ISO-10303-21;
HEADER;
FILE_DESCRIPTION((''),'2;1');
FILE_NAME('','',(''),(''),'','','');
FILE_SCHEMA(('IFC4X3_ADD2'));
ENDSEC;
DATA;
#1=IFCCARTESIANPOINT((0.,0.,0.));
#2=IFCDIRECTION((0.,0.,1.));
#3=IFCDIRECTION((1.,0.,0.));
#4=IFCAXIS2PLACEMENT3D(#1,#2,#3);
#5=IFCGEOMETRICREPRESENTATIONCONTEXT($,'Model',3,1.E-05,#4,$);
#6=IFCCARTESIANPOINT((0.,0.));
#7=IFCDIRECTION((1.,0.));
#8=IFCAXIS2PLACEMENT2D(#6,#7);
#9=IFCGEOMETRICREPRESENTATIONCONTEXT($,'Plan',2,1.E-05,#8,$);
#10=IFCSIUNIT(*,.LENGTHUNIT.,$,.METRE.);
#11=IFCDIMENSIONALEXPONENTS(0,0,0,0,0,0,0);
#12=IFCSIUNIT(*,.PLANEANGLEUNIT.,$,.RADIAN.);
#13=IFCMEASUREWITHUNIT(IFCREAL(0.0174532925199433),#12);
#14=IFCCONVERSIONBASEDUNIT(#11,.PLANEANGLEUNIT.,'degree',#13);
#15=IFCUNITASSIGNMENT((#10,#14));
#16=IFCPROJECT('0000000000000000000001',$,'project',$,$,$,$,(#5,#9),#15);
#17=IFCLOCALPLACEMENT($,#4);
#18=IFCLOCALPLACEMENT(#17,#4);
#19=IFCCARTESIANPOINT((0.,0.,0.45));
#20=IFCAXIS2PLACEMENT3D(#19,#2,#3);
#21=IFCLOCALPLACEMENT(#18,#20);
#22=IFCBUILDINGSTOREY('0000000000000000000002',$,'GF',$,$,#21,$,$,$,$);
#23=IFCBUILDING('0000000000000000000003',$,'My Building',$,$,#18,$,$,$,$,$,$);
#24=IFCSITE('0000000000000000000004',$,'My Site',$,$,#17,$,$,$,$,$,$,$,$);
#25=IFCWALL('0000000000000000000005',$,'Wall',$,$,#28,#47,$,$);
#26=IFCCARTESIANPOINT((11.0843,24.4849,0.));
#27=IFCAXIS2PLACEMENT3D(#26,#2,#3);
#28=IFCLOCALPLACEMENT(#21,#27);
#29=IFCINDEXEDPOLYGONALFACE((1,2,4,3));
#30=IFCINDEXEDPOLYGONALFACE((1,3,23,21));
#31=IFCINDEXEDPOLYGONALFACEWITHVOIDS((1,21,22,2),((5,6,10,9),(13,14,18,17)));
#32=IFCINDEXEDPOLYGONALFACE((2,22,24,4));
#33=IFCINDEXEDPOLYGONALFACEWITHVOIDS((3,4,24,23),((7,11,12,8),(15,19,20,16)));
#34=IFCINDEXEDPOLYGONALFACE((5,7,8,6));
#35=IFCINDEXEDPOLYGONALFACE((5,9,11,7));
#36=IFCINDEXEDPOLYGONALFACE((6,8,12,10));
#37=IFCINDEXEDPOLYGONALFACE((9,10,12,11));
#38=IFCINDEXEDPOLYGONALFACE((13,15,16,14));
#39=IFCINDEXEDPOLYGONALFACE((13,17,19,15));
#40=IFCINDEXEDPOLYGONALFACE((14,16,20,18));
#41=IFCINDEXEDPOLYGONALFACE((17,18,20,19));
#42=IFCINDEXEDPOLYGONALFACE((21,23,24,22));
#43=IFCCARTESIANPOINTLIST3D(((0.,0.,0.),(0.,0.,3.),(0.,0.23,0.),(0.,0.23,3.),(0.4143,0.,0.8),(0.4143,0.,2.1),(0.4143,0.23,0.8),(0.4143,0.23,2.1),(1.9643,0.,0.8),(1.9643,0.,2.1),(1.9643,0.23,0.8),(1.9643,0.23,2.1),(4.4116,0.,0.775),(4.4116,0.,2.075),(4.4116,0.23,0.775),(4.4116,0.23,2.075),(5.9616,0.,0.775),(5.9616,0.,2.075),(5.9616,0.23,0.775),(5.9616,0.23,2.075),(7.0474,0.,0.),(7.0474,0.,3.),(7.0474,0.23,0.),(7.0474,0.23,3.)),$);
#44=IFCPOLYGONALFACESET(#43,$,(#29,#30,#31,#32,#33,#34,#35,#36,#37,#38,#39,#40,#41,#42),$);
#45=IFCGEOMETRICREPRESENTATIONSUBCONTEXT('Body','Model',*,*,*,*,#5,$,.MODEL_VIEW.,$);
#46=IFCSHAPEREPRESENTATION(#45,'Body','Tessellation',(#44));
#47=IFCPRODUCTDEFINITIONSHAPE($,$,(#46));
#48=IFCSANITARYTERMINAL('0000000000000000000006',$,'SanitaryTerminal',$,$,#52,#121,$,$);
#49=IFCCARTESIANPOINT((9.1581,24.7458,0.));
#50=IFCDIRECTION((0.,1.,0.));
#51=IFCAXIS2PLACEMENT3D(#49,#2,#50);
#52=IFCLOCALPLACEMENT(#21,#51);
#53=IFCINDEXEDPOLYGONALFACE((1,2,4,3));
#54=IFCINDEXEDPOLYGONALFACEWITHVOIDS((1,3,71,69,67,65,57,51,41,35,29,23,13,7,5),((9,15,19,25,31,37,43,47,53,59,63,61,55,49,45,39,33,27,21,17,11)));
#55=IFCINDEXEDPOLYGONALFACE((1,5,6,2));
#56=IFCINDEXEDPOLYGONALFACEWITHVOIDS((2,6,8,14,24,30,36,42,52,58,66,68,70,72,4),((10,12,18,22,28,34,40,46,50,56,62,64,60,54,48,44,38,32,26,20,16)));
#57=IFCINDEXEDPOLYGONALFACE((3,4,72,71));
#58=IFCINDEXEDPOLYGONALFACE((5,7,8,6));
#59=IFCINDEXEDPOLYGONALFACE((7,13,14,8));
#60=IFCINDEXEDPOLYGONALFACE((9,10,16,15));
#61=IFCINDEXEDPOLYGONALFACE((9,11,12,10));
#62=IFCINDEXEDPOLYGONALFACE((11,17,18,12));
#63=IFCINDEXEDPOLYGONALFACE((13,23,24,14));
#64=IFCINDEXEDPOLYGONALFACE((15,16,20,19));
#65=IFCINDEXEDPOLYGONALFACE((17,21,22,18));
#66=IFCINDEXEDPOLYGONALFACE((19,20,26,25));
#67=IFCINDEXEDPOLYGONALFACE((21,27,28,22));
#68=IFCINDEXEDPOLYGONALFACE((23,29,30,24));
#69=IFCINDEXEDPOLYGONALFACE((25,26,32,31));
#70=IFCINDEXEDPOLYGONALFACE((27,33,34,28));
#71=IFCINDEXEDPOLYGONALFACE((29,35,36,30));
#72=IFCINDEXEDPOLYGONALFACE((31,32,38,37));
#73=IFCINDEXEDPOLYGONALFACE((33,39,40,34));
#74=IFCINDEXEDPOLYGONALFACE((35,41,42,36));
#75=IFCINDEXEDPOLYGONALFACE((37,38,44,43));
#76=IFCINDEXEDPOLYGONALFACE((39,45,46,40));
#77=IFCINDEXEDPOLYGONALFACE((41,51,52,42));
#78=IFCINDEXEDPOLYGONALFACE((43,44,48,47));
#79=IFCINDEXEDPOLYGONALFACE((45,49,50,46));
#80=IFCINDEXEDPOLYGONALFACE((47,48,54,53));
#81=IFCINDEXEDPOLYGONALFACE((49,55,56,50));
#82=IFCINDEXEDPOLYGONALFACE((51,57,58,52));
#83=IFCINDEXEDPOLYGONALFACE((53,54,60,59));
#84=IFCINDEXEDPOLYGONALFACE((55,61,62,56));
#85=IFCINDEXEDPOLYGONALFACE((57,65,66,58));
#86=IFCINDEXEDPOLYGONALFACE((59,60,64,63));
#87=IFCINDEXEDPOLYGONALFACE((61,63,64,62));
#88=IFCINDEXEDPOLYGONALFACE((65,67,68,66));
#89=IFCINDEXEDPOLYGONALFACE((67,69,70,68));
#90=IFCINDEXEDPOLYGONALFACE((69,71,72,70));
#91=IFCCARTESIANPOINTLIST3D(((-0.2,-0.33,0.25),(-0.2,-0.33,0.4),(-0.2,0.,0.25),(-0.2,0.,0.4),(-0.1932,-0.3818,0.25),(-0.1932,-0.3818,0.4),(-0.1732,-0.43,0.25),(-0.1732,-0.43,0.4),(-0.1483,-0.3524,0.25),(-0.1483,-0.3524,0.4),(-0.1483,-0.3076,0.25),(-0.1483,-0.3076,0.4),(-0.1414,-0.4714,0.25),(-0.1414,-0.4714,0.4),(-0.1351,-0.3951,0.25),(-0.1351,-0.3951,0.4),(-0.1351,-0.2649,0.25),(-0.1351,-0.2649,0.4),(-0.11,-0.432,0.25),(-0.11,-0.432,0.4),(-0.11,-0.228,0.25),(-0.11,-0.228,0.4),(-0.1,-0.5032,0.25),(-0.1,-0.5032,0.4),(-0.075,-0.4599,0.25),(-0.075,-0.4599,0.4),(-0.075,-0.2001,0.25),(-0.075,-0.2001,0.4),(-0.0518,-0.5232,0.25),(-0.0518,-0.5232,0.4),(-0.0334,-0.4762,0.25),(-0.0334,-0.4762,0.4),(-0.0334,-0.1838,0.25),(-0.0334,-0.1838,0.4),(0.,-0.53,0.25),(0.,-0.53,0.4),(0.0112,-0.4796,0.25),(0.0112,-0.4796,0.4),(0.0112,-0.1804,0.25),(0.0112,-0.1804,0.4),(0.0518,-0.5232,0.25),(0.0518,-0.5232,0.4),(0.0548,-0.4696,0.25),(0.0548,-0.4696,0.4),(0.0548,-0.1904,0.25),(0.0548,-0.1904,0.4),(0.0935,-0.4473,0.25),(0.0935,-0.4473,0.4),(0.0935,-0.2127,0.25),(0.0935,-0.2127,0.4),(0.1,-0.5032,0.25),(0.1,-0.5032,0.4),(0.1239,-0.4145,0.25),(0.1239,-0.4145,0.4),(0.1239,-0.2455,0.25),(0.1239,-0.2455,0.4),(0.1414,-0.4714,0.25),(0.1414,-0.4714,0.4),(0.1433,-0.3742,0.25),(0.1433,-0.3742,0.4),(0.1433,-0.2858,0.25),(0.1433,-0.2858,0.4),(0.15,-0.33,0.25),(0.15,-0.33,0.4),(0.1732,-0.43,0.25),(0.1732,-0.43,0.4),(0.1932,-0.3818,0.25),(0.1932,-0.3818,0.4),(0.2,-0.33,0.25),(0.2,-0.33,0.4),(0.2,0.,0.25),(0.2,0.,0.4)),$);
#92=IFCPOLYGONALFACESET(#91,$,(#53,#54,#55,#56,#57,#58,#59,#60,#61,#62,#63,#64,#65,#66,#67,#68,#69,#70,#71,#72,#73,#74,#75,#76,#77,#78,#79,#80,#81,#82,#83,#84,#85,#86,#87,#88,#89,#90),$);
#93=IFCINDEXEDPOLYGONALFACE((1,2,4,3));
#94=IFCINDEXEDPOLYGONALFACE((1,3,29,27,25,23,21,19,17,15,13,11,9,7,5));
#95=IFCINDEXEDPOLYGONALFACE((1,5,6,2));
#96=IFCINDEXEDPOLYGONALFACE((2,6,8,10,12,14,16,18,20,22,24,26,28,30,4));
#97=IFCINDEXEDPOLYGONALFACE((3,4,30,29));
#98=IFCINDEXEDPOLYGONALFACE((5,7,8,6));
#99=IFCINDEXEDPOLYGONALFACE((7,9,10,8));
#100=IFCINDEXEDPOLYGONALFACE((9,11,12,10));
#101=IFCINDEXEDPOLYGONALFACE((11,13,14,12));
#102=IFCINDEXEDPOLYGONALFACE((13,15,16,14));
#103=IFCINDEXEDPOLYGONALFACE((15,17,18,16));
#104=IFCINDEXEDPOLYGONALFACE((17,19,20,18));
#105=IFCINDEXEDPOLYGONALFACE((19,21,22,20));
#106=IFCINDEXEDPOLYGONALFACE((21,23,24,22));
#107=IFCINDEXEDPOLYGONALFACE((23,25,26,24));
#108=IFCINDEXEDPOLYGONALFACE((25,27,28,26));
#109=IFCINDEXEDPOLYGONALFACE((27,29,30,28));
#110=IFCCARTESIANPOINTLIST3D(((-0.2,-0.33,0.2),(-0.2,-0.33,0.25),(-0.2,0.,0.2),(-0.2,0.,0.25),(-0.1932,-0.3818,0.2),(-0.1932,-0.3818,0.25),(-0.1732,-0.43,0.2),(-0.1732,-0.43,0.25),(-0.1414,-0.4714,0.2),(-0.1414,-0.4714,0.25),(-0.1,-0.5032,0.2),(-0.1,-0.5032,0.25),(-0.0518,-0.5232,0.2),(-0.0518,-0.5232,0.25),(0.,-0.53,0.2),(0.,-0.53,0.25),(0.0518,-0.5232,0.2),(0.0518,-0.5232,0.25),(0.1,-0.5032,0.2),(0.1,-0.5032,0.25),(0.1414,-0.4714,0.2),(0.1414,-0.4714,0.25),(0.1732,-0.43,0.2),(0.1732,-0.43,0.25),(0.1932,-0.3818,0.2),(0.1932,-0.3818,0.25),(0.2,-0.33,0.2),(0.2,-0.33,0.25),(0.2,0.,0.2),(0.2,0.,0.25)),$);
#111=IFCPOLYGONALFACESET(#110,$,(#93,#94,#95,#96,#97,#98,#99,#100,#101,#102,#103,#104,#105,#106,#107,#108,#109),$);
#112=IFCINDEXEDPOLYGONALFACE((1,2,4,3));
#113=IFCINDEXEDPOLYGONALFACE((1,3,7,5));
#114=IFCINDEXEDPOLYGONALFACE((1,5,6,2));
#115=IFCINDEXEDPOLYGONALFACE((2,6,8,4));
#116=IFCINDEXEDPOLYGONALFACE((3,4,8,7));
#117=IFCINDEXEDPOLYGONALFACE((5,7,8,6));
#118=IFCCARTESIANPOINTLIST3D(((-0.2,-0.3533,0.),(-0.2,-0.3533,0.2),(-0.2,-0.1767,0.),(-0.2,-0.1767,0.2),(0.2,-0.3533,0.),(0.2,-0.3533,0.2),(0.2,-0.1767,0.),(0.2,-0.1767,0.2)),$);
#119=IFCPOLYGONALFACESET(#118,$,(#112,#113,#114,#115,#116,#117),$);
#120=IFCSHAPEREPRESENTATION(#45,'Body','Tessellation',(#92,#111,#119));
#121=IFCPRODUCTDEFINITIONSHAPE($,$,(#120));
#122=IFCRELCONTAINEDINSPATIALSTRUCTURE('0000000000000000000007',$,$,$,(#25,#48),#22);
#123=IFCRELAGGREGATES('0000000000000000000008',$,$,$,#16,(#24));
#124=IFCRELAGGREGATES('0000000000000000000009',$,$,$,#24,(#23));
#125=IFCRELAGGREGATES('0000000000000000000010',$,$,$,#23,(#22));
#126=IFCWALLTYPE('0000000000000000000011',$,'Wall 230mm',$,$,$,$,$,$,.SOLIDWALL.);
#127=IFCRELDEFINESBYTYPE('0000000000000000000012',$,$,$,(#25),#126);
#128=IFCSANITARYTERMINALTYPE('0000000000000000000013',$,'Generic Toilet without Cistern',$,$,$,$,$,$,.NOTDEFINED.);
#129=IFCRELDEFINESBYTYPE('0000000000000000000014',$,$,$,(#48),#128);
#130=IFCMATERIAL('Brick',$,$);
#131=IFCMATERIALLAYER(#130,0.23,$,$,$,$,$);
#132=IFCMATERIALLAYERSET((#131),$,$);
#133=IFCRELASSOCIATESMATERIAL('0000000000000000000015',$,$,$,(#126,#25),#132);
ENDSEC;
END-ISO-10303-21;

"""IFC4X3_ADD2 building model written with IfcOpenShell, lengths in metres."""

from ifc_helpers import new_model, entity, si_unit, converted_unit, frame, frame_2d, origin_with_axes, origin_2d_with_axis, place, context, subcontext, project, spatial, line, arc, indexed_curve, circle_curve, outline, extrude, shape, source, transform, mapped, material, layer, layer_set, layer_usage, type_object, type_shapes, element, save


model = new_model("IFC4X3_ADD2")

# Units and contexts
model_context = context("Model", 3, precision=1e-05, world=origin_with_axes())
plan_context = context("Plan", 2, precision=1e-05, world=origin_2d_with_axis())
body_context_1 = subcontext(model_context, "Body", "Model", "MODEL_VIEW")
body_context_2 = subcontext(plan_context, "Body", "Plan", "PLAN_VIEW")
ifc_project = project(units=[si_unit("LENGTHUNIT", "METRE"), converted_unit("PLANEANGLEUNIT", "degree", entity("IfcReal", 0.0174532925199433), si_unit("PLANEANGLEUNIT", "RADIAN"), dimensions=[0, 0, 0, 0, 0, 0, 0])], contexts=[model_context, plan_context])

# Site, building, storey
site_placement = place(None, origin_with_axes())
site = spatial("IfcSite", under=ifc_project, at=site_placement, Name="My Site")
building_placement = place(site_placement, origin_with_axes())
building = spatial("IfcBuilding", under=site, at=building_placement, Name="My Building")
storey_placement = place(building_placement, frame((0.0, 0.0, 0.45), z_axis=(0.0, 0.0, 1.0), x_axis=(1.0, 0.0, 0.0)))
storey = spatial("IfcBuildingStorey", under=building, at=storey_placement, Name="GF")

# Shared definitions
ifc_material = material(Name="Brick")
ifc_layer_1 = layer(ifc_material, 0.23)
ifc_layer_set_1 = layer_set([ifc_layer_1])
wall_type_1 = type_object("IfcWallType", Name="Wall 230mm", PredefinedType="SOLIDWALL", material=ifc_layer_set_1)

# Wall, openings
ifc_layer_usage_1 = layer_usage(ifc_layer_set_1, "AXIS2", "POSITIVE", 0.0)
wall_1_placement = place(storey_placement, frame((11.0843, 24.4849, 0.0), z_axis=(0.0, 0.0, 1.0), x_axis=(1.0, 0.0, 0.0)))
wall_1 = element("IfcWall", 1, at=wall_1_placement, inside=storey, type_object=wall_type_1, material=ifc_layer_usage_1, Name="Wall", context=body_context_1, shape_type="SweptSolid", body=[
    extrude(outline(indexed_curve([(0.0, 0.0), (0.0, 0.23), (7.0474, 0.23), (7.0474, 0.0), (0.0, 0.0)], self_intersect=False)), origin_with_axes(), (0.0, 0.0, 1.0), 3.0),
])
shared_shape_1 = source(origin_with_axes(), body_context_1, "Body", "SweptSolid", [
    extrude(outline(indexed_curve([(0.0, 0.0), (1.55, 0.0), (1.55, 1.3), (0.0, 1.3)], segments=[line(1, 2, 3, 4, 1)])), frame((-0.775, -0.6, 0.0), z_axis=(0.0, -1.0, 0.0), x_axis=(1.0, 0.0, 0.0)), (0.0, 0.0, -1.0), 1.2),
])
opening_1_placement = place(wall_1_placement, frame((5.1866, 0.2, 0.775), z_axis=(0.0, 0.0, 1.0), x_axis=(-1.0, 0.0, 0.0)))
element("IfcOpeningElement", 2, at=opening_1_placement, cuts=wall_1, PredefinedType="OPENING", context=body_context_1, shape_type="MappedRepresentation", body=[
    mapped(shared_shape_1, transform((0.0, 0.0, 0.0), x_axis=(1.0, 0.0, 0.0), y_axis=(0.0, 1.0, 0.0), z_axis=(0.0, 0.0, 1.0), scale=1.0)),
])
opening_2_placement = place(wall_1_placement, frame((1.1893, 0.0, 0.8), z_axis=(0.0, 0.0, 1.0), x_axis=(1.0, 0.0, 0.0)))
element("IfcOpeningElement", 3, at=opening_2_placement, cuts=wall_1, PredefinedType="OPENING", context=body_context_1, shape_type="MappedRepresentation", body=[
    mapped(shared_shape_1, transform((0.0, 0.0, 0.0), x_axis=(1.0, 0.0, 0.0), y_axis=(0.0, 1.0, 0.0), z_axis=(0.0, 0.0, 1.0), scale=1.0)),
])

# Sanitary terminal
sanitary_terminal_type_1 = type_object("IfcSanitaryTerminalType", Name="Generic Toilet without Cistern", PredefinedType="NOTDEFINED")
shared_shape_2 = source(origin_with_axes(), body_context_1, "Body", "SweptSolid", [
    extrude(outline(indexed_curve([(-0.2, 0.0), (0.2, 0.0), (0.2, -0.33), (0.1414, -0.4714), (0.0, -0.53), (-0.1414, -0.4714), (-0.2, -0.33)], segments=[line(1, 2), line(2, 3), arc(3, 4, 5), arc(5, 6, 7), line(7, 1)]), holes=[circle_curve(frame_2d((0.0, -0.33)), 0.15)]), frame((0.0, 0.0, 0.25), z_axis=(0.0, 0.0, 1.0), x_axis=(1.0, 0.0, 0.0)), (0.0, 0.0, 1.0), 0.15),
    extrude(outline(indexed_curve([(-0.2, 0.0), (0.2, 0.0), (0.2, -0.33), (0.1414, -0.4714), (0.0, -0.53), (-0.1414, -0.4714), (-0.2, -0.33)], segments=[line(1, 2), line(2, 3), arc(3, 4, 5), arc(5, 6, 7), line(7, 1)])), frame((0.0, 0.0, 0.2), z_axis=(0.0, 0.0, 1.0), x_axis=(1.0, 0.0, 0.0)), (0.0, 0.0, 1.0), 0.05),
    extrude(outline(indexed_curve([(-0.2, -0.1767), (0.2, -0.1767), (0.2, -0.3533), (-0.2, -0.3533)], segments=[line(1, 2, 3, 4, 1)])), origin_with_axes(), (0.0, 0.0, 1.0), 0.2),
])
shared_shape_3 = source(origin_with_axes(), body_context_2, "Body", "Annotation2D", [
    entity("IfcGeometricCurveSet", [entity("IfcIndexedPolyCurve", entity("IfcCartesianPointList2D", [[-0.1068, -0.124], [-0.0957, -0.1129], [-0.0804, -0.1088], [0.0804, -0.1088], [0.0957, -0.1129], [0.1068, -0.124], [0.1109, -0.1393], [0.1109, -0.3476], [0.1025, -0.3926], [0.0784, -0.4308], [0.0424, -0.4563], [0.0, -0.4652], [-0.0424, -0.4563], [-0.0784, -0.4308], [-0.1025, -0.3926], [-0.1109, -0.3476], [-0.1109, -0.1393]]), [entity("IfcLineIndex", [1, 2, 3, 4, 5, 6, 7, 8, 9, 10, 11, 12, 13, 14, 15, 16, 17, 1])]), entity("IfcIndexedPolyCurve", entity("IfcCartesianPointList2D", [[-0.1962, -0.2314], [-0.1848, -0.301], [-0.1764, -0.3339], [-0.1663, -0.3651], [-0.1546, -0.3944], [-0.1414, -0.4213], [-0.1269, -0.4458], [-0.1111, -0.4675], [-0.0943, -0.4862], [-0.0765, -0.5018], [-0.0581, -0.514], [-0.039, -0.5229], [-0.0196, -0.5282], [0.0, -0.53], [0.0196, -0.5282], [0.039, -0.5229], [0.0581, -0.514], [0.0765, -0.5018], [0.0943, -0.4862], [0.1111, -0.4675], [0.1269, -0.4458], [0.1414, -0.4213], [0.1546, -0.3944], [0.1663, -0.3651], [0.1764, -0.3339], [0.1848, -0.301], [0.1962, -0.2314], [0.2, -0.159], [0.1872, 0.0], [-0.1872, 0.0], [-0.2, -0.159]]), [entity("IfcLineIndex", [1, 2, 3, 4, 5, 6, 7, 8, 9, 10, 11, 12, 13, 14, 15, 16, 17, 18, 19, 20, 21, 22, 23, 24, 25, 26, 27, 28, 29, 30, 31, 1])])]),
])
type_shapes(sanitary_terminal_type_1, [shared_shape_2, shared_shape_3])
for number, where, z_axis, x_axis, name in (
    (4, (9.1581, 24.7458, 0.0), (0.0, 0.0, 1.0), (0.0, 1.0, 0.0), "SanitaryTerminal"),
):
    element("IfcSanitaryTerminal", number, at=place(storey_placement, frame(where, z_axis=z_axis, x_axis=x_axis)), inside=storey, type_object=sanitary_terminal_type_1, Name=name, shapes=[
        shape(body_context_1, "Body", "MappedRepresentation", [mapped(shared_shape_2, transform((0.0, 0.0, 0.0), x_axis=(1.0, 0.0, 0.0), y_axis=(0.0, 1.0, 0.0), z_axis=(0.0, 0.0, 1.0), scale=1.0))]),
        shape(body_context_2, "Body", "MappedRepresentation", [mapped(shared_shape_3, transform((0.0, 0.0, 0.0), x_axis=(1.0, 0.0, 0.0), y_axis=(0.0, 1.0, 0.0), z_axis=(0.0, 0.0, 1.0), scale=1.0))]),
    ])

save(model, "model.ifc")
